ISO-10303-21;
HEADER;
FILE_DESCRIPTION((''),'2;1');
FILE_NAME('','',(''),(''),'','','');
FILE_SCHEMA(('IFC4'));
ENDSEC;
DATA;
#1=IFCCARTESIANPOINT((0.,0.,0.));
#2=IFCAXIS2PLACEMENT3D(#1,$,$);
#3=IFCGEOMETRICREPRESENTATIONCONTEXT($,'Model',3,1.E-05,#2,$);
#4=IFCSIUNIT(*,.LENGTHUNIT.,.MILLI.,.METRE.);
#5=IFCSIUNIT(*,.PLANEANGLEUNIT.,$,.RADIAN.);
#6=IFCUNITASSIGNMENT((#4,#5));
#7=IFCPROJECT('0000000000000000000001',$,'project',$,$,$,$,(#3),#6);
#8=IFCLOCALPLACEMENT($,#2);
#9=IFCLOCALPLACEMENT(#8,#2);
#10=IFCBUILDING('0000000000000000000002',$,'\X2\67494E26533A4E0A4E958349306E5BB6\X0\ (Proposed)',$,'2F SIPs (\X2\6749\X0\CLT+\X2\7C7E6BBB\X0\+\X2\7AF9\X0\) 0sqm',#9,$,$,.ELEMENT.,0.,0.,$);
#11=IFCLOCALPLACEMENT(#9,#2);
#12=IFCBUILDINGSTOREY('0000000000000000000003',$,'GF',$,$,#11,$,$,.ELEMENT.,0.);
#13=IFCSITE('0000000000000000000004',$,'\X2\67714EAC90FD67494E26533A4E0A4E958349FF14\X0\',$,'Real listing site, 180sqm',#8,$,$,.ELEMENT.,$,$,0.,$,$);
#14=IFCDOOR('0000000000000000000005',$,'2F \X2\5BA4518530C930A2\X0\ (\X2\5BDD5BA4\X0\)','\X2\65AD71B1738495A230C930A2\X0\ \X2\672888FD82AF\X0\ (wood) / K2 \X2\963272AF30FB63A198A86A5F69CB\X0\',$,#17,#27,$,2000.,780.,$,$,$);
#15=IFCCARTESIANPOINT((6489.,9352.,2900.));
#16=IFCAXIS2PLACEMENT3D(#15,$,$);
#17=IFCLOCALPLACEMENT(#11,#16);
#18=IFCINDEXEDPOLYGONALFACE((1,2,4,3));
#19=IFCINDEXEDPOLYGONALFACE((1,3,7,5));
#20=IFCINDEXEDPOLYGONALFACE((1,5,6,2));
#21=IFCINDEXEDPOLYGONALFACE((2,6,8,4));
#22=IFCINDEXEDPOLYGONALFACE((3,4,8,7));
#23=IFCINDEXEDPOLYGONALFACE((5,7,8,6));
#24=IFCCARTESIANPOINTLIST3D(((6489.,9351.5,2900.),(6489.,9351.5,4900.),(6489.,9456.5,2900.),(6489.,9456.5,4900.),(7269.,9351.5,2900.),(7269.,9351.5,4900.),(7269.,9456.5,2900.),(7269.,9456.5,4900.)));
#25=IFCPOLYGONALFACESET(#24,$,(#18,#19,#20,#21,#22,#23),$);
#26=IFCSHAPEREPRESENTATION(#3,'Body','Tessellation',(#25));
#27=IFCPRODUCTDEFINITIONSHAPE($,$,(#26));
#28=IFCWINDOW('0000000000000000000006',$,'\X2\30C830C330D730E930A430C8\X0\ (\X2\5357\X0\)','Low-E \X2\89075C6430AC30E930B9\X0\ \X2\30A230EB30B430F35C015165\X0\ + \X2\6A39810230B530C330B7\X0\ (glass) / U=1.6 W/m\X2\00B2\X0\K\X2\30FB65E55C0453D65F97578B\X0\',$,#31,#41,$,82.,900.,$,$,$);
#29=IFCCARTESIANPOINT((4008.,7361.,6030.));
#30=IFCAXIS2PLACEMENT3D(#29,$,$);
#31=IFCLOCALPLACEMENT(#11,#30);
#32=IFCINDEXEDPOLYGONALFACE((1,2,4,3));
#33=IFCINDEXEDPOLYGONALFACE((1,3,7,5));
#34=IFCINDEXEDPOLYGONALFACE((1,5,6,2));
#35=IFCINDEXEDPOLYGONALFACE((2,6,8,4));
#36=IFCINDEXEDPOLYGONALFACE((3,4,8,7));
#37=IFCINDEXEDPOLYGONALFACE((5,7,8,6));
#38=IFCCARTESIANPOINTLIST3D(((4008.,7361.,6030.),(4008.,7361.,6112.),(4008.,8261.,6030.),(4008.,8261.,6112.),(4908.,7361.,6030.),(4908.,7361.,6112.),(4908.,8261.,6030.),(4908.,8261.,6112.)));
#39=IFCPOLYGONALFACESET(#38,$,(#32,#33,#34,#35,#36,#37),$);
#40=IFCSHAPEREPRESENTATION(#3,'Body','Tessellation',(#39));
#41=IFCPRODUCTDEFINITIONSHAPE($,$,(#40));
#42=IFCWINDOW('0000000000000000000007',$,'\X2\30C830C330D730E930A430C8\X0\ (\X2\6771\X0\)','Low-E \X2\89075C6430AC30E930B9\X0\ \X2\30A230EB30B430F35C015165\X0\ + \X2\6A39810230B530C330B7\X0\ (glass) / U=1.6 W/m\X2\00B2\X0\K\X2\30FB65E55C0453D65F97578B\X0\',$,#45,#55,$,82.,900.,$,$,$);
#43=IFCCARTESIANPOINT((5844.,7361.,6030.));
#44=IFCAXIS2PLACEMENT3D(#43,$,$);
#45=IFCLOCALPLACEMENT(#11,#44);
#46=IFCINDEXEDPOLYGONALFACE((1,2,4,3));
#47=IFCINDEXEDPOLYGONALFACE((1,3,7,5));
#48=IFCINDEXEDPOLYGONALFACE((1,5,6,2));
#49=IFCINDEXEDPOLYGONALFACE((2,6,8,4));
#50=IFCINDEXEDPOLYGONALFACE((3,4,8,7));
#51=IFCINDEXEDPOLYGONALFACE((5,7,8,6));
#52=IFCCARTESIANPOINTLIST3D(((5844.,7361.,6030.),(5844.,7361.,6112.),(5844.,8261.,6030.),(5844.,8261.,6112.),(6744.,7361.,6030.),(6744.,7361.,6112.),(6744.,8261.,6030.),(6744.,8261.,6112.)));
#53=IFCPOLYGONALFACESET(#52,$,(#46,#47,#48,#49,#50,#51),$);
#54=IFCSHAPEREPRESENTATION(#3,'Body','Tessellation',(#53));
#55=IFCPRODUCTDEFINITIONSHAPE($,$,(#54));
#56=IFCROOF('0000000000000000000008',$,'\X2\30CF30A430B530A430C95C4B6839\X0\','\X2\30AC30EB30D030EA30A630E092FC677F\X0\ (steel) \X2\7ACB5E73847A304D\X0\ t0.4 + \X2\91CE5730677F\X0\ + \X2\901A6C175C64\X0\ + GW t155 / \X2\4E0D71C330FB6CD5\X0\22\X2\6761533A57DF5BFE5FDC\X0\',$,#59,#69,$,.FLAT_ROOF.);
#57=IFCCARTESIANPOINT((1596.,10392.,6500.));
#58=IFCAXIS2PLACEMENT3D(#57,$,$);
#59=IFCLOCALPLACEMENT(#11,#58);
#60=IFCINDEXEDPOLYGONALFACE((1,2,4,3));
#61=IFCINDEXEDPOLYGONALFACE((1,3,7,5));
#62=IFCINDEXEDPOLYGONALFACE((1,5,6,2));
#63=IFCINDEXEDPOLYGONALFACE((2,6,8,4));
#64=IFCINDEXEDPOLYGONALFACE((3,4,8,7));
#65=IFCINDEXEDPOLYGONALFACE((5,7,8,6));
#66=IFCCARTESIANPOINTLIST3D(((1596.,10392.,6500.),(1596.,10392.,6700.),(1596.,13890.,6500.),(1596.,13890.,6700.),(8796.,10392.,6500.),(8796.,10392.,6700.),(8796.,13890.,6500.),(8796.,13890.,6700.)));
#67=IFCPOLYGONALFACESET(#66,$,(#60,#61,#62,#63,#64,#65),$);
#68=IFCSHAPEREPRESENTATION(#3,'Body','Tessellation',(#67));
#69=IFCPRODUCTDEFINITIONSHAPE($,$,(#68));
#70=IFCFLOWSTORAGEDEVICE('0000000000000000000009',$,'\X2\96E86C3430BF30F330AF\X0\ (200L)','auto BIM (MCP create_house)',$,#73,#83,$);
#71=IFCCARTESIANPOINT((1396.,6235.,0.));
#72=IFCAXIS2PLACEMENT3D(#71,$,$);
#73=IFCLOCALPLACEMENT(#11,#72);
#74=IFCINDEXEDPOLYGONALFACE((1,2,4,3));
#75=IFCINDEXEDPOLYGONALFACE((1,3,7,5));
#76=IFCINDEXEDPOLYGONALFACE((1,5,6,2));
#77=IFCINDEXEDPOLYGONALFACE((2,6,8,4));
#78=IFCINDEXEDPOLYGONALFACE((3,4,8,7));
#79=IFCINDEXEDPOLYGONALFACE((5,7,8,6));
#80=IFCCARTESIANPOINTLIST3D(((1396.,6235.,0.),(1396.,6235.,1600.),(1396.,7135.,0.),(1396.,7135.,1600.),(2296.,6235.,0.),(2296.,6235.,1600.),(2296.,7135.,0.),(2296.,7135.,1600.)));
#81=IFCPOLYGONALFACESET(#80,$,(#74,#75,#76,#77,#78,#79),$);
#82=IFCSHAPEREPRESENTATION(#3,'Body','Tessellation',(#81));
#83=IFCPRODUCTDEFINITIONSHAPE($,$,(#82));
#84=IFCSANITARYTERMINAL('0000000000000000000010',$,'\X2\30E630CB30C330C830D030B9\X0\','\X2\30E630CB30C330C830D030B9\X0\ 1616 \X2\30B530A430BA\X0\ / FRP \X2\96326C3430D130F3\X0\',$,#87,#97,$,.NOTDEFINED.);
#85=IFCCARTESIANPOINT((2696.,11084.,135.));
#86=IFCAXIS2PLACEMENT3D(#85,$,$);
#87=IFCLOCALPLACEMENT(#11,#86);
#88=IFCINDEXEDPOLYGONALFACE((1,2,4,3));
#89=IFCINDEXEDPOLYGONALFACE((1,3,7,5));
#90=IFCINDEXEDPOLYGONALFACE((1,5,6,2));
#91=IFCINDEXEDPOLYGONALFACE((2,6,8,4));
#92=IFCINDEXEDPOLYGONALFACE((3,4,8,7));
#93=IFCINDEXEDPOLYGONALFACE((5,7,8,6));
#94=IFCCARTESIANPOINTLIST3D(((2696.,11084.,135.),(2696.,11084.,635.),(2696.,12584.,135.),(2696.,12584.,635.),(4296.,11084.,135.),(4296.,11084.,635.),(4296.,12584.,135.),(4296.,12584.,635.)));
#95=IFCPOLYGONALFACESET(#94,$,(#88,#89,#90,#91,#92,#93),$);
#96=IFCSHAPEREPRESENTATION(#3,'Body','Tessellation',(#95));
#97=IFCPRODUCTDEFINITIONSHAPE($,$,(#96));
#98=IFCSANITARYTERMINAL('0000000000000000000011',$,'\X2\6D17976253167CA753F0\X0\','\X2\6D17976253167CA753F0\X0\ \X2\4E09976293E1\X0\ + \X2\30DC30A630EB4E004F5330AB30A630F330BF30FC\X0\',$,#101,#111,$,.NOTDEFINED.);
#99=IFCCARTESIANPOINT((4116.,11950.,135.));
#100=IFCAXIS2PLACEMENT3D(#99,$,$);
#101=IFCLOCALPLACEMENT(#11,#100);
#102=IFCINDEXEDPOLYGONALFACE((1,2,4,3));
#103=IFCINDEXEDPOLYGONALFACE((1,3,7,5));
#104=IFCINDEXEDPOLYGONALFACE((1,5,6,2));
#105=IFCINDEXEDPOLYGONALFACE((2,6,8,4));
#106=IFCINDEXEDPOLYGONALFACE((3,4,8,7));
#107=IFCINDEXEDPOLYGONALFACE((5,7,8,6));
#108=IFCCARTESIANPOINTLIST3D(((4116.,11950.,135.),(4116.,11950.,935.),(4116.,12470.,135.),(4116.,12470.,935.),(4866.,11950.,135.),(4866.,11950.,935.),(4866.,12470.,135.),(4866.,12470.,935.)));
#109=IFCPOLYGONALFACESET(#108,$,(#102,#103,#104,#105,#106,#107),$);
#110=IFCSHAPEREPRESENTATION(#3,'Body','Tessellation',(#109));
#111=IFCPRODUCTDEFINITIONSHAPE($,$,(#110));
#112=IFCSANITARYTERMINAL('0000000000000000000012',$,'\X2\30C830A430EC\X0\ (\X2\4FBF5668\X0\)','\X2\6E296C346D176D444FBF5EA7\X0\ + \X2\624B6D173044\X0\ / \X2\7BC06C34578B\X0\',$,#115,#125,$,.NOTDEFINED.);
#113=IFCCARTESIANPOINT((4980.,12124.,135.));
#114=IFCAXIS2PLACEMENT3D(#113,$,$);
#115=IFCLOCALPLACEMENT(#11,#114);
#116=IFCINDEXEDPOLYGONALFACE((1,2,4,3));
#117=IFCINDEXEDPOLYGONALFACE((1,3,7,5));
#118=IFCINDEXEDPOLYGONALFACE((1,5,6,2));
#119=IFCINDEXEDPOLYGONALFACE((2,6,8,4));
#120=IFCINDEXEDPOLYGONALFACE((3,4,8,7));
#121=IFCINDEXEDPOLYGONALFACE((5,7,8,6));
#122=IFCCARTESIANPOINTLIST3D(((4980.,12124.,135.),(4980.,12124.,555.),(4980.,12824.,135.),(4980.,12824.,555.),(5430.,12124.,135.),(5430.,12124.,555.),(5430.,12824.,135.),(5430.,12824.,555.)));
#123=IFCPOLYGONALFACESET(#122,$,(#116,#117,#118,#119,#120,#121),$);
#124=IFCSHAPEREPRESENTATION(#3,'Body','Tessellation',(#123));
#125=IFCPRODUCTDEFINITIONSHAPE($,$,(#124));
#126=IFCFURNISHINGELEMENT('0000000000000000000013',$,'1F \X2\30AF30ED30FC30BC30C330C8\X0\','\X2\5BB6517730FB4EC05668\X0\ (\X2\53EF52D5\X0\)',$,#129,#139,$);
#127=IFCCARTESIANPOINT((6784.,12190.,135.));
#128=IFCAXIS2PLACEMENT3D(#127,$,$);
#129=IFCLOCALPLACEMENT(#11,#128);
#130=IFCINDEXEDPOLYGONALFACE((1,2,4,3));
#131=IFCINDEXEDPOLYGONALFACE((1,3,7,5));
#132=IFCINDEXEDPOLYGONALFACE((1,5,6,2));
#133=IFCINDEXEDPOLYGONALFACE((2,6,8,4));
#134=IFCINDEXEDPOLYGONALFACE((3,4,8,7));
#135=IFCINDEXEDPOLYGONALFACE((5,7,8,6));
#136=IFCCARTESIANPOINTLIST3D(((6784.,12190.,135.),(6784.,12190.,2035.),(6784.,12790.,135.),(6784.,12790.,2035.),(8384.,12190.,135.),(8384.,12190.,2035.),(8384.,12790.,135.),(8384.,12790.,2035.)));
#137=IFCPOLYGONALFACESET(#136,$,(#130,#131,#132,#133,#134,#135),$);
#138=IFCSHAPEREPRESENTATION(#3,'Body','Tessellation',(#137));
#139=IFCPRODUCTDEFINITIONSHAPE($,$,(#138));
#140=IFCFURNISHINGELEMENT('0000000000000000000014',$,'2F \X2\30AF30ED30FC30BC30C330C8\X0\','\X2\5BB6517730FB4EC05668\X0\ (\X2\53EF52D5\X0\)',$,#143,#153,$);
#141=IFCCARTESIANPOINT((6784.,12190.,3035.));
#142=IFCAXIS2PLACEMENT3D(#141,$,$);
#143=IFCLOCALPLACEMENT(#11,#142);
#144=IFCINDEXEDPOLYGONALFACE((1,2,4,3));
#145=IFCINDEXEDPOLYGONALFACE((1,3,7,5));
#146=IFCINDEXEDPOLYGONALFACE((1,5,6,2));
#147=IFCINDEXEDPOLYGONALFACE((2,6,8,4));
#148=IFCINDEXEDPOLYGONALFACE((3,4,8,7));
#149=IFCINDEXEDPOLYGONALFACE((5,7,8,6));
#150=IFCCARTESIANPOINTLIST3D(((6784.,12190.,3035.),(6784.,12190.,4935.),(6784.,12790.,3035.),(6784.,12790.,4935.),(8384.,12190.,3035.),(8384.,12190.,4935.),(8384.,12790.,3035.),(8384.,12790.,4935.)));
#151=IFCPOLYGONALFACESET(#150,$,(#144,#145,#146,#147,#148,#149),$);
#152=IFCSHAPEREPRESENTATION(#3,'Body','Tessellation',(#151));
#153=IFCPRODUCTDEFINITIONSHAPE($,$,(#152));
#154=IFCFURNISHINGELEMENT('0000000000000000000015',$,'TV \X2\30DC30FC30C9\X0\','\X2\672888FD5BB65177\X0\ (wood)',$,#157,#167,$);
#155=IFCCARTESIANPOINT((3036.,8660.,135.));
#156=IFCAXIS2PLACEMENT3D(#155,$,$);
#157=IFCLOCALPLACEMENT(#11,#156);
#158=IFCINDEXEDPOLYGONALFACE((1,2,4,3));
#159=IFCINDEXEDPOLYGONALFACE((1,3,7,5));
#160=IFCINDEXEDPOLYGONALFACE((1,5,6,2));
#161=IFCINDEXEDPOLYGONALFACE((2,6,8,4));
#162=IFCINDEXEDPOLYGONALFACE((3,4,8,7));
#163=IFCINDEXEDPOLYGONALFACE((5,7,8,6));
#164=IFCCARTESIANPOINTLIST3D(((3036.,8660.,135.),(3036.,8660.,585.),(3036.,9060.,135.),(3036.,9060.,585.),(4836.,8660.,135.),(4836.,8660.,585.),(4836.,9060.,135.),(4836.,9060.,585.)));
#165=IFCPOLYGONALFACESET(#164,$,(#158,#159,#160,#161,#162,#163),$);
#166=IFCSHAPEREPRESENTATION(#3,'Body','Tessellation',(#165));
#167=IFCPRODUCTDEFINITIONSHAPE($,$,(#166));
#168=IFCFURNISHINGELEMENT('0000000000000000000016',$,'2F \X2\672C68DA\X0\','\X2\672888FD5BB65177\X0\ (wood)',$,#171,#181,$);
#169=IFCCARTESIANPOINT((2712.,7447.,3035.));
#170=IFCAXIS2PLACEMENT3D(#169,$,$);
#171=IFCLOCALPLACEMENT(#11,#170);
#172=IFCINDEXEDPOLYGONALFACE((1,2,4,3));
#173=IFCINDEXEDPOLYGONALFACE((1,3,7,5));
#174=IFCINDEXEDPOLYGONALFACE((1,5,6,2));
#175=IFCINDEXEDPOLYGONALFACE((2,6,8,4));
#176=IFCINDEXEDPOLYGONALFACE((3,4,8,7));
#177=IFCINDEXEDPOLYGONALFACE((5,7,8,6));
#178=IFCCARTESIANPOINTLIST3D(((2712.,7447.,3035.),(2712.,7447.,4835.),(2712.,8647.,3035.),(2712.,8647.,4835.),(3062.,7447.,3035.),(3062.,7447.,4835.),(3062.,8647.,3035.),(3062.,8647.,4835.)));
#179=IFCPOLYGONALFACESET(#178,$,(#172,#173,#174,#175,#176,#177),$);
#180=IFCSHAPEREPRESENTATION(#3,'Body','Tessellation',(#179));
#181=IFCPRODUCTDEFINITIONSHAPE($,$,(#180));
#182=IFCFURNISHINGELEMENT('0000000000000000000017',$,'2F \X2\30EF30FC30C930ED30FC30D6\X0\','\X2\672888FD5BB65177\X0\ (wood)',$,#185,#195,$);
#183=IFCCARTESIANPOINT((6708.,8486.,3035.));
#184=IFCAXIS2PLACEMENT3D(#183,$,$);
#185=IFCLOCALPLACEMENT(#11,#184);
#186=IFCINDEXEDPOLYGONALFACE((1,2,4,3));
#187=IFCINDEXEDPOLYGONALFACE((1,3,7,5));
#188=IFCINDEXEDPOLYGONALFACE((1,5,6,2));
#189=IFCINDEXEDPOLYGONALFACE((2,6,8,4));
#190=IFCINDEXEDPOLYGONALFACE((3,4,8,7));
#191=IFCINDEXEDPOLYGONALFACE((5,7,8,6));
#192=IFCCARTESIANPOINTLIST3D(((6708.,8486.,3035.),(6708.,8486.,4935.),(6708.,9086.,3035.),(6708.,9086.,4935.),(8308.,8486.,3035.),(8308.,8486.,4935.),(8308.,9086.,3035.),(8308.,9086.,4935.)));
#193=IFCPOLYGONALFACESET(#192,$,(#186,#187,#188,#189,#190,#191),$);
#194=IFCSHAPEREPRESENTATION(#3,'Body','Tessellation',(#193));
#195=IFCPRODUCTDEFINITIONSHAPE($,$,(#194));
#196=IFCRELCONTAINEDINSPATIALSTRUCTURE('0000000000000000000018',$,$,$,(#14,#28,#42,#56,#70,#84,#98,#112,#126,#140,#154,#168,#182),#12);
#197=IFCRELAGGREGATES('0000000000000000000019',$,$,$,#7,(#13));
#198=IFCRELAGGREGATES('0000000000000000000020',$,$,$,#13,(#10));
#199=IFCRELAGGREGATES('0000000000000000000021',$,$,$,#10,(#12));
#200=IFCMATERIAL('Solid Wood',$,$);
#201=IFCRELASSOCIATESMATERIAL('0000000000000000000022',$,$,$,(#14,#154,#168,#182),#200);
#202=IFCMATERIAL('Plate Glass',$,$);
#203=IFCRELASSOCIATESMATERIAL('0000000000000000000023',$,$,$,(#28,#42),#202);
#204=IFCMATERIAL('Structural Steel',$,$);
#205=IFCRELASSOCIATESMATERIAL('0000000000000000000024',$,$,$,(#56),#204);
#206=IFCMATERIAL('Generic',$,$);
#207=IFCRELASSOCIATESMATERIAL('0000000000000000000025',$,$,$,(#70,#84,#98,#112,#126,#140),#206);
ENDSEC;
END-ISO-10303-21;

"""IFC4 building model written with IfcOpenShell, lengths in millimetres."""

from ifc_helpers import new_model, si_unit, frame, frame_2d, origin, place, context, project, spatial, rectangle, extrude, material, element, save


model = new_model("IFC4")

# Units and contexts
model_context = context("Model", 3, precision=1e-05, world=origin())
ifc_project = project(units=[si_unit("LENGTHUNIT", "METRE", prefix="MILLI"), si_unit("PLANEANGLEUNIT", "RADIAN")], contexts=[model_context])

# Site, building, storey
site_placement = place(None, origin())
site = spatial("IfcSite", under=ifc_project, at=site_placement, Name="東京都杉並区上井草４", ObjectType="Real listing site, 180sqm", CompositionType="ELEMENT", RefElevation=0.0)
building_placement = place(site_placement, origin())
building = spatial("IfcBuilding", under=site, at=building_placement, Name="杉並区上井草の家 (Proposed)", ObjectType="2F SIPs (杉CLT+籾殻+竹) 0sqm", CompositionType="ELEMENT", ElevationOfRefHeight=0.0, ElevationOfTerrain=0.0)
storey_placement = place(building_placement, origin())
storey = spatial("IfcBuildingStorey", under=building, at=storey_placement, Name="GF", CompositionType="ELEMENT", Elevation=0.0)

# Shared definitions
ifc_material_1 = material(Name="Solid Wood")
ifc_material_2 = material(Name="Plate Glass")

# Door
door_1_placement = place(storey_placement, frame((6489.0, 9352.0, 2900.0)))
element("IfcDoor", 1, at=door_1_placement, inside=storey, material=ifc_material_1, Name="2F 室内ドア (寝室)", Description="断熱玄関ドア 木製芯 (wood) / K2 防犯・採風機構", OverallHeight=2000.0, OverallWidth=780.0, context=model_context, shape_type="SweptSolid", body=[
    extrude(rectangle(XDim=780.0, YDim=105.0, at=frame_2d((390.0, 52.0))), frame((6489.0, 9352.0, 2900.0)), (0.0, 0.0, 1.0), 2000.0),
])

# Windows
window_1_placement = place(storey_placement, frame((4008.0, 7361.0, 6030.0)))
element("IfcWindow", 2, at=window_1_placement, inside=storey, material=ifc_material_2, Name="トップライト (南)", Description="Low-E 複層ガラス アルゴン封入 + 樹脂サッシ (glass) / U=1.6 W/m²K・日射取得型", OverallHeight=82.0, OverallWidth=900.0, context=model_context, shape_type="SweptSolid", body=[
    extrude(rectangle(XDim=900.0, YDim=900.0, at=frame_2d((450.0, 450.0))), frame((4008.0, 7361.0, 6030.0)), (0.0, 0.0, 1.0), 82.0),
])
window_2_placement = place(storey_placement, frame((5844.0, 7361.0, 6030.0)))
element("IfcWindow", 3, at=window_2_placement, inside=storey, material=ifc_material_2, Name="トップライト (東)", Description="Low-E 複層ガラス アルゴン封入 + 樹脂サッシ (glass) / U=1.6 W/m²K・日射取得型", OverallHeight=82.0, OverallWidth=900.0, context=model_context, shape_type="SweptSolid", body=[
    extrude(rectangle(XDim=900.0, YDim=900.0, at=frame_2d((450.0, 450.0))), frame((5844.0, 7361.0, 6030.0)), (0.0, 0.0, 1.0), 82.0),
])

# Roof
ifc_material_3 = material(Name="Structural Steel")
roof_placement = place(storey_placement, frame((1596.0, 10392.0, 6500.0)))
element("IfcRoof", 4, at=roof_placement, inside=storey, material=ifc_material_3, Name="ハイサイド屋根", Description="ガルバリウム鋼板 (steel) 立平葺き t0.4 + 野地板 + 通気層 + GW t155 / 不燃・法22条区域対応", PredefinedType="FLAT_ROOF", context=model_context, shape_type="SweptSolid", body=[
    extrude(rectangle(XDim=7200.0, YDim=3498.0, at=frame_2d((3600.0, 1749.0))), frame((1596.0, 10392.0, 6500.0)), (0.0, 0.0, 1.0), 200.0),
])

# Flow storage device
ifc_material_4 = material(Name="Generic")
flow_storage_device_placement = place(storey_placement, frame((1396.0, 6235.0, 0.0)))
element("IfcFlowStorageDevice", 5, at=flow_storage_device_placement, inside=storey, material=ifc_material_4, Name="雨水タンク (200L)", Description="auto BIM (MCP create_house)", context=model_context, shape_type="SweptSolid", body=[
    extrude(rectangle(XDim=900.0, YDim=900.0, at=frame_2d((450.0, 450.0))), frame((1396.0, 6235.0, 0.0)), (0.0, 0.0, 1.0), 1600.0),
])

# Sanitary terminals
sanitary_terminal_1_placement = place(storey_placement, frame((2696.0, 11084.0, 135.0)))
element("IfcSanitaryTerminal", 6, at=sanitary_terminal_1_placement, inside=storey, material=ifc_material_4, Name="ユニットバス", Description="ユニットバス 1616 サイズ / FRP 防水パン", PredefinedType="NOTDEFINED", context=model_context, shape_type="SweptSolid", body=[
    extrude(rectangle(XDim=1600.0, YDim=1500.0, at=frame_2d((800.0, 750.0))), frame((2696.0, 11084.0, 135.0)), (0.0, 0.0, 1.0), 500.0),
])
sanitary_terminal_2_placement = place(storey_placement, frame((4116.0, 11950.0, 135.0)))
element("IfcSanitaryTerminal", 7, at=sanitary_terminal_2_placement, inside=storey, material=ifc_material_4, Name="洗面化粧台", Description="洗面化粧台 三面鏡 + ボウル一体カウンター", PredefinedType="NOTDEFINED", context=model_context, shape_type="SweptSolid", body=[
    extrude(rectangle(XDim=750.0, YDim=520.0, at=frame_2d((375.0, 260.0))), frame((4116.0, 11950.0, 135.0)), (0.0, 0.0, 1.0), 800.0),
])
sanitary_terminal_3_placement = place(storey_placement, frame((4980.0, 12124.0, 135.0)))
element("IfcSanitaryTerminal", 8, at=sanitary_terminal_3_placement, inside=storey, material=ifc_material_4, Name="トイレ (便器)", Description="温水洗浄便座 + 手洗い / 節水型", PredefinedType="NOTDEFINED", context=model_context, shape_type="SweptSolid", body=[
    extrude(rectangle(XDim=450.0, YDim=700.0, at=frame_2d((225.0, 350.0))), frame((4980.0, 12124.0, 135.0)), (0.0, 0.0, 1.0), 420.0),
])

# Furnishing elements
furnishing_1_placement = place(storey_placement, frame((6784.0, 12190.0, 135.0)))
element("IfcFurnishingElement", 9, at=furnishing_1_placement, inside=storey, material=ifc_material_4, Name="1F クローゼット", Description="家具・什器 (可動)", context=model_context, shape_type="SweptSolid", body=[
    extrude(rectangle(XDim=1600.0, YDim=600.0, at=frame_2d((800.0, 300.0))), frame((6784.0, 12190.0, 135.0)), (0.0, 0.0, 1.0), 1900.0),
])
furnishing_2_placement = place(storey_placement, frame((6784.0, 12190.0, 3035.0)))
element("IfcFurnishingElement", 10, at=furnishing_2_placement, inside=storey, material=ifc_material_4, Name="2F クローゼット", Description="家具・什器 (可動)", context=model_context, shape_type="SweptSolid", body=[
    extrude(rectangle(XDim=1600.0, YDim=600.0, at=frame_2d((800.0, 300.0))), frame((6784.0, 12190.0, 3035.0)), (0.0, 0.0, 1.0), 1900.0),
])
furnishing_3_placement = place(storey_placement, frame((3036.0, 8660.0, 135.0)))
element("IfcFurnishingElement", 11, at=furnishing_3_placement, inside=storey, material=ifc_material_1, Name="TV ボード", Description="木製家具 (wood)", context=model_context, shape_type="SweptSolid", body=[
    extrude(rectangle(XDim=1800.0, YDim=400.0, at=frame_2d((900.0, 200.0))), frame((3036.0, 8660.0, 135.0)), (0.0, 0.0, 1.0), 450.0),
])
furnishing_4_placement = place(storey_placement, frame((2712.0, 7447.0, 3035.0)))
element("IfcFurnishingElement", 12, at=furnishing_4_placement, inside=storey, material=ifc_material_1, Name="2F 本棚", Description="木製家具 (wood)", context=model_context, shape_type="SweptSolid", body=[
    extrude(rectangle(XDim=350.0, YDim=1200.0, at=frame_2d((175.0, 600.0))), frame((2712.0, 7447.0, 3035.0)), (0.0, 0.0, 1.0), 1800.0),
])
furnishing_5_placement = place(storey_placement, frame((6708.0, 8486.0, 3035.0)))
element("IfcFurnishingElement", 13, at=furnishing_5_placement, inside=storey, material=ifc_material_1, Name="2F ワードローブ", Description="木製家具 (wood)", context=model_context, shape_type="SweptSolid", body=[
    extrude(rectangle(XDim=1600.0, YDim=600.0, at=frame_2d((800.0, 300.0))), frame((6708.0, 8486.0, 3035.0)), (0.0, 0.0, 1.0), 1900.0),
])

save(model, "model.ifc")
